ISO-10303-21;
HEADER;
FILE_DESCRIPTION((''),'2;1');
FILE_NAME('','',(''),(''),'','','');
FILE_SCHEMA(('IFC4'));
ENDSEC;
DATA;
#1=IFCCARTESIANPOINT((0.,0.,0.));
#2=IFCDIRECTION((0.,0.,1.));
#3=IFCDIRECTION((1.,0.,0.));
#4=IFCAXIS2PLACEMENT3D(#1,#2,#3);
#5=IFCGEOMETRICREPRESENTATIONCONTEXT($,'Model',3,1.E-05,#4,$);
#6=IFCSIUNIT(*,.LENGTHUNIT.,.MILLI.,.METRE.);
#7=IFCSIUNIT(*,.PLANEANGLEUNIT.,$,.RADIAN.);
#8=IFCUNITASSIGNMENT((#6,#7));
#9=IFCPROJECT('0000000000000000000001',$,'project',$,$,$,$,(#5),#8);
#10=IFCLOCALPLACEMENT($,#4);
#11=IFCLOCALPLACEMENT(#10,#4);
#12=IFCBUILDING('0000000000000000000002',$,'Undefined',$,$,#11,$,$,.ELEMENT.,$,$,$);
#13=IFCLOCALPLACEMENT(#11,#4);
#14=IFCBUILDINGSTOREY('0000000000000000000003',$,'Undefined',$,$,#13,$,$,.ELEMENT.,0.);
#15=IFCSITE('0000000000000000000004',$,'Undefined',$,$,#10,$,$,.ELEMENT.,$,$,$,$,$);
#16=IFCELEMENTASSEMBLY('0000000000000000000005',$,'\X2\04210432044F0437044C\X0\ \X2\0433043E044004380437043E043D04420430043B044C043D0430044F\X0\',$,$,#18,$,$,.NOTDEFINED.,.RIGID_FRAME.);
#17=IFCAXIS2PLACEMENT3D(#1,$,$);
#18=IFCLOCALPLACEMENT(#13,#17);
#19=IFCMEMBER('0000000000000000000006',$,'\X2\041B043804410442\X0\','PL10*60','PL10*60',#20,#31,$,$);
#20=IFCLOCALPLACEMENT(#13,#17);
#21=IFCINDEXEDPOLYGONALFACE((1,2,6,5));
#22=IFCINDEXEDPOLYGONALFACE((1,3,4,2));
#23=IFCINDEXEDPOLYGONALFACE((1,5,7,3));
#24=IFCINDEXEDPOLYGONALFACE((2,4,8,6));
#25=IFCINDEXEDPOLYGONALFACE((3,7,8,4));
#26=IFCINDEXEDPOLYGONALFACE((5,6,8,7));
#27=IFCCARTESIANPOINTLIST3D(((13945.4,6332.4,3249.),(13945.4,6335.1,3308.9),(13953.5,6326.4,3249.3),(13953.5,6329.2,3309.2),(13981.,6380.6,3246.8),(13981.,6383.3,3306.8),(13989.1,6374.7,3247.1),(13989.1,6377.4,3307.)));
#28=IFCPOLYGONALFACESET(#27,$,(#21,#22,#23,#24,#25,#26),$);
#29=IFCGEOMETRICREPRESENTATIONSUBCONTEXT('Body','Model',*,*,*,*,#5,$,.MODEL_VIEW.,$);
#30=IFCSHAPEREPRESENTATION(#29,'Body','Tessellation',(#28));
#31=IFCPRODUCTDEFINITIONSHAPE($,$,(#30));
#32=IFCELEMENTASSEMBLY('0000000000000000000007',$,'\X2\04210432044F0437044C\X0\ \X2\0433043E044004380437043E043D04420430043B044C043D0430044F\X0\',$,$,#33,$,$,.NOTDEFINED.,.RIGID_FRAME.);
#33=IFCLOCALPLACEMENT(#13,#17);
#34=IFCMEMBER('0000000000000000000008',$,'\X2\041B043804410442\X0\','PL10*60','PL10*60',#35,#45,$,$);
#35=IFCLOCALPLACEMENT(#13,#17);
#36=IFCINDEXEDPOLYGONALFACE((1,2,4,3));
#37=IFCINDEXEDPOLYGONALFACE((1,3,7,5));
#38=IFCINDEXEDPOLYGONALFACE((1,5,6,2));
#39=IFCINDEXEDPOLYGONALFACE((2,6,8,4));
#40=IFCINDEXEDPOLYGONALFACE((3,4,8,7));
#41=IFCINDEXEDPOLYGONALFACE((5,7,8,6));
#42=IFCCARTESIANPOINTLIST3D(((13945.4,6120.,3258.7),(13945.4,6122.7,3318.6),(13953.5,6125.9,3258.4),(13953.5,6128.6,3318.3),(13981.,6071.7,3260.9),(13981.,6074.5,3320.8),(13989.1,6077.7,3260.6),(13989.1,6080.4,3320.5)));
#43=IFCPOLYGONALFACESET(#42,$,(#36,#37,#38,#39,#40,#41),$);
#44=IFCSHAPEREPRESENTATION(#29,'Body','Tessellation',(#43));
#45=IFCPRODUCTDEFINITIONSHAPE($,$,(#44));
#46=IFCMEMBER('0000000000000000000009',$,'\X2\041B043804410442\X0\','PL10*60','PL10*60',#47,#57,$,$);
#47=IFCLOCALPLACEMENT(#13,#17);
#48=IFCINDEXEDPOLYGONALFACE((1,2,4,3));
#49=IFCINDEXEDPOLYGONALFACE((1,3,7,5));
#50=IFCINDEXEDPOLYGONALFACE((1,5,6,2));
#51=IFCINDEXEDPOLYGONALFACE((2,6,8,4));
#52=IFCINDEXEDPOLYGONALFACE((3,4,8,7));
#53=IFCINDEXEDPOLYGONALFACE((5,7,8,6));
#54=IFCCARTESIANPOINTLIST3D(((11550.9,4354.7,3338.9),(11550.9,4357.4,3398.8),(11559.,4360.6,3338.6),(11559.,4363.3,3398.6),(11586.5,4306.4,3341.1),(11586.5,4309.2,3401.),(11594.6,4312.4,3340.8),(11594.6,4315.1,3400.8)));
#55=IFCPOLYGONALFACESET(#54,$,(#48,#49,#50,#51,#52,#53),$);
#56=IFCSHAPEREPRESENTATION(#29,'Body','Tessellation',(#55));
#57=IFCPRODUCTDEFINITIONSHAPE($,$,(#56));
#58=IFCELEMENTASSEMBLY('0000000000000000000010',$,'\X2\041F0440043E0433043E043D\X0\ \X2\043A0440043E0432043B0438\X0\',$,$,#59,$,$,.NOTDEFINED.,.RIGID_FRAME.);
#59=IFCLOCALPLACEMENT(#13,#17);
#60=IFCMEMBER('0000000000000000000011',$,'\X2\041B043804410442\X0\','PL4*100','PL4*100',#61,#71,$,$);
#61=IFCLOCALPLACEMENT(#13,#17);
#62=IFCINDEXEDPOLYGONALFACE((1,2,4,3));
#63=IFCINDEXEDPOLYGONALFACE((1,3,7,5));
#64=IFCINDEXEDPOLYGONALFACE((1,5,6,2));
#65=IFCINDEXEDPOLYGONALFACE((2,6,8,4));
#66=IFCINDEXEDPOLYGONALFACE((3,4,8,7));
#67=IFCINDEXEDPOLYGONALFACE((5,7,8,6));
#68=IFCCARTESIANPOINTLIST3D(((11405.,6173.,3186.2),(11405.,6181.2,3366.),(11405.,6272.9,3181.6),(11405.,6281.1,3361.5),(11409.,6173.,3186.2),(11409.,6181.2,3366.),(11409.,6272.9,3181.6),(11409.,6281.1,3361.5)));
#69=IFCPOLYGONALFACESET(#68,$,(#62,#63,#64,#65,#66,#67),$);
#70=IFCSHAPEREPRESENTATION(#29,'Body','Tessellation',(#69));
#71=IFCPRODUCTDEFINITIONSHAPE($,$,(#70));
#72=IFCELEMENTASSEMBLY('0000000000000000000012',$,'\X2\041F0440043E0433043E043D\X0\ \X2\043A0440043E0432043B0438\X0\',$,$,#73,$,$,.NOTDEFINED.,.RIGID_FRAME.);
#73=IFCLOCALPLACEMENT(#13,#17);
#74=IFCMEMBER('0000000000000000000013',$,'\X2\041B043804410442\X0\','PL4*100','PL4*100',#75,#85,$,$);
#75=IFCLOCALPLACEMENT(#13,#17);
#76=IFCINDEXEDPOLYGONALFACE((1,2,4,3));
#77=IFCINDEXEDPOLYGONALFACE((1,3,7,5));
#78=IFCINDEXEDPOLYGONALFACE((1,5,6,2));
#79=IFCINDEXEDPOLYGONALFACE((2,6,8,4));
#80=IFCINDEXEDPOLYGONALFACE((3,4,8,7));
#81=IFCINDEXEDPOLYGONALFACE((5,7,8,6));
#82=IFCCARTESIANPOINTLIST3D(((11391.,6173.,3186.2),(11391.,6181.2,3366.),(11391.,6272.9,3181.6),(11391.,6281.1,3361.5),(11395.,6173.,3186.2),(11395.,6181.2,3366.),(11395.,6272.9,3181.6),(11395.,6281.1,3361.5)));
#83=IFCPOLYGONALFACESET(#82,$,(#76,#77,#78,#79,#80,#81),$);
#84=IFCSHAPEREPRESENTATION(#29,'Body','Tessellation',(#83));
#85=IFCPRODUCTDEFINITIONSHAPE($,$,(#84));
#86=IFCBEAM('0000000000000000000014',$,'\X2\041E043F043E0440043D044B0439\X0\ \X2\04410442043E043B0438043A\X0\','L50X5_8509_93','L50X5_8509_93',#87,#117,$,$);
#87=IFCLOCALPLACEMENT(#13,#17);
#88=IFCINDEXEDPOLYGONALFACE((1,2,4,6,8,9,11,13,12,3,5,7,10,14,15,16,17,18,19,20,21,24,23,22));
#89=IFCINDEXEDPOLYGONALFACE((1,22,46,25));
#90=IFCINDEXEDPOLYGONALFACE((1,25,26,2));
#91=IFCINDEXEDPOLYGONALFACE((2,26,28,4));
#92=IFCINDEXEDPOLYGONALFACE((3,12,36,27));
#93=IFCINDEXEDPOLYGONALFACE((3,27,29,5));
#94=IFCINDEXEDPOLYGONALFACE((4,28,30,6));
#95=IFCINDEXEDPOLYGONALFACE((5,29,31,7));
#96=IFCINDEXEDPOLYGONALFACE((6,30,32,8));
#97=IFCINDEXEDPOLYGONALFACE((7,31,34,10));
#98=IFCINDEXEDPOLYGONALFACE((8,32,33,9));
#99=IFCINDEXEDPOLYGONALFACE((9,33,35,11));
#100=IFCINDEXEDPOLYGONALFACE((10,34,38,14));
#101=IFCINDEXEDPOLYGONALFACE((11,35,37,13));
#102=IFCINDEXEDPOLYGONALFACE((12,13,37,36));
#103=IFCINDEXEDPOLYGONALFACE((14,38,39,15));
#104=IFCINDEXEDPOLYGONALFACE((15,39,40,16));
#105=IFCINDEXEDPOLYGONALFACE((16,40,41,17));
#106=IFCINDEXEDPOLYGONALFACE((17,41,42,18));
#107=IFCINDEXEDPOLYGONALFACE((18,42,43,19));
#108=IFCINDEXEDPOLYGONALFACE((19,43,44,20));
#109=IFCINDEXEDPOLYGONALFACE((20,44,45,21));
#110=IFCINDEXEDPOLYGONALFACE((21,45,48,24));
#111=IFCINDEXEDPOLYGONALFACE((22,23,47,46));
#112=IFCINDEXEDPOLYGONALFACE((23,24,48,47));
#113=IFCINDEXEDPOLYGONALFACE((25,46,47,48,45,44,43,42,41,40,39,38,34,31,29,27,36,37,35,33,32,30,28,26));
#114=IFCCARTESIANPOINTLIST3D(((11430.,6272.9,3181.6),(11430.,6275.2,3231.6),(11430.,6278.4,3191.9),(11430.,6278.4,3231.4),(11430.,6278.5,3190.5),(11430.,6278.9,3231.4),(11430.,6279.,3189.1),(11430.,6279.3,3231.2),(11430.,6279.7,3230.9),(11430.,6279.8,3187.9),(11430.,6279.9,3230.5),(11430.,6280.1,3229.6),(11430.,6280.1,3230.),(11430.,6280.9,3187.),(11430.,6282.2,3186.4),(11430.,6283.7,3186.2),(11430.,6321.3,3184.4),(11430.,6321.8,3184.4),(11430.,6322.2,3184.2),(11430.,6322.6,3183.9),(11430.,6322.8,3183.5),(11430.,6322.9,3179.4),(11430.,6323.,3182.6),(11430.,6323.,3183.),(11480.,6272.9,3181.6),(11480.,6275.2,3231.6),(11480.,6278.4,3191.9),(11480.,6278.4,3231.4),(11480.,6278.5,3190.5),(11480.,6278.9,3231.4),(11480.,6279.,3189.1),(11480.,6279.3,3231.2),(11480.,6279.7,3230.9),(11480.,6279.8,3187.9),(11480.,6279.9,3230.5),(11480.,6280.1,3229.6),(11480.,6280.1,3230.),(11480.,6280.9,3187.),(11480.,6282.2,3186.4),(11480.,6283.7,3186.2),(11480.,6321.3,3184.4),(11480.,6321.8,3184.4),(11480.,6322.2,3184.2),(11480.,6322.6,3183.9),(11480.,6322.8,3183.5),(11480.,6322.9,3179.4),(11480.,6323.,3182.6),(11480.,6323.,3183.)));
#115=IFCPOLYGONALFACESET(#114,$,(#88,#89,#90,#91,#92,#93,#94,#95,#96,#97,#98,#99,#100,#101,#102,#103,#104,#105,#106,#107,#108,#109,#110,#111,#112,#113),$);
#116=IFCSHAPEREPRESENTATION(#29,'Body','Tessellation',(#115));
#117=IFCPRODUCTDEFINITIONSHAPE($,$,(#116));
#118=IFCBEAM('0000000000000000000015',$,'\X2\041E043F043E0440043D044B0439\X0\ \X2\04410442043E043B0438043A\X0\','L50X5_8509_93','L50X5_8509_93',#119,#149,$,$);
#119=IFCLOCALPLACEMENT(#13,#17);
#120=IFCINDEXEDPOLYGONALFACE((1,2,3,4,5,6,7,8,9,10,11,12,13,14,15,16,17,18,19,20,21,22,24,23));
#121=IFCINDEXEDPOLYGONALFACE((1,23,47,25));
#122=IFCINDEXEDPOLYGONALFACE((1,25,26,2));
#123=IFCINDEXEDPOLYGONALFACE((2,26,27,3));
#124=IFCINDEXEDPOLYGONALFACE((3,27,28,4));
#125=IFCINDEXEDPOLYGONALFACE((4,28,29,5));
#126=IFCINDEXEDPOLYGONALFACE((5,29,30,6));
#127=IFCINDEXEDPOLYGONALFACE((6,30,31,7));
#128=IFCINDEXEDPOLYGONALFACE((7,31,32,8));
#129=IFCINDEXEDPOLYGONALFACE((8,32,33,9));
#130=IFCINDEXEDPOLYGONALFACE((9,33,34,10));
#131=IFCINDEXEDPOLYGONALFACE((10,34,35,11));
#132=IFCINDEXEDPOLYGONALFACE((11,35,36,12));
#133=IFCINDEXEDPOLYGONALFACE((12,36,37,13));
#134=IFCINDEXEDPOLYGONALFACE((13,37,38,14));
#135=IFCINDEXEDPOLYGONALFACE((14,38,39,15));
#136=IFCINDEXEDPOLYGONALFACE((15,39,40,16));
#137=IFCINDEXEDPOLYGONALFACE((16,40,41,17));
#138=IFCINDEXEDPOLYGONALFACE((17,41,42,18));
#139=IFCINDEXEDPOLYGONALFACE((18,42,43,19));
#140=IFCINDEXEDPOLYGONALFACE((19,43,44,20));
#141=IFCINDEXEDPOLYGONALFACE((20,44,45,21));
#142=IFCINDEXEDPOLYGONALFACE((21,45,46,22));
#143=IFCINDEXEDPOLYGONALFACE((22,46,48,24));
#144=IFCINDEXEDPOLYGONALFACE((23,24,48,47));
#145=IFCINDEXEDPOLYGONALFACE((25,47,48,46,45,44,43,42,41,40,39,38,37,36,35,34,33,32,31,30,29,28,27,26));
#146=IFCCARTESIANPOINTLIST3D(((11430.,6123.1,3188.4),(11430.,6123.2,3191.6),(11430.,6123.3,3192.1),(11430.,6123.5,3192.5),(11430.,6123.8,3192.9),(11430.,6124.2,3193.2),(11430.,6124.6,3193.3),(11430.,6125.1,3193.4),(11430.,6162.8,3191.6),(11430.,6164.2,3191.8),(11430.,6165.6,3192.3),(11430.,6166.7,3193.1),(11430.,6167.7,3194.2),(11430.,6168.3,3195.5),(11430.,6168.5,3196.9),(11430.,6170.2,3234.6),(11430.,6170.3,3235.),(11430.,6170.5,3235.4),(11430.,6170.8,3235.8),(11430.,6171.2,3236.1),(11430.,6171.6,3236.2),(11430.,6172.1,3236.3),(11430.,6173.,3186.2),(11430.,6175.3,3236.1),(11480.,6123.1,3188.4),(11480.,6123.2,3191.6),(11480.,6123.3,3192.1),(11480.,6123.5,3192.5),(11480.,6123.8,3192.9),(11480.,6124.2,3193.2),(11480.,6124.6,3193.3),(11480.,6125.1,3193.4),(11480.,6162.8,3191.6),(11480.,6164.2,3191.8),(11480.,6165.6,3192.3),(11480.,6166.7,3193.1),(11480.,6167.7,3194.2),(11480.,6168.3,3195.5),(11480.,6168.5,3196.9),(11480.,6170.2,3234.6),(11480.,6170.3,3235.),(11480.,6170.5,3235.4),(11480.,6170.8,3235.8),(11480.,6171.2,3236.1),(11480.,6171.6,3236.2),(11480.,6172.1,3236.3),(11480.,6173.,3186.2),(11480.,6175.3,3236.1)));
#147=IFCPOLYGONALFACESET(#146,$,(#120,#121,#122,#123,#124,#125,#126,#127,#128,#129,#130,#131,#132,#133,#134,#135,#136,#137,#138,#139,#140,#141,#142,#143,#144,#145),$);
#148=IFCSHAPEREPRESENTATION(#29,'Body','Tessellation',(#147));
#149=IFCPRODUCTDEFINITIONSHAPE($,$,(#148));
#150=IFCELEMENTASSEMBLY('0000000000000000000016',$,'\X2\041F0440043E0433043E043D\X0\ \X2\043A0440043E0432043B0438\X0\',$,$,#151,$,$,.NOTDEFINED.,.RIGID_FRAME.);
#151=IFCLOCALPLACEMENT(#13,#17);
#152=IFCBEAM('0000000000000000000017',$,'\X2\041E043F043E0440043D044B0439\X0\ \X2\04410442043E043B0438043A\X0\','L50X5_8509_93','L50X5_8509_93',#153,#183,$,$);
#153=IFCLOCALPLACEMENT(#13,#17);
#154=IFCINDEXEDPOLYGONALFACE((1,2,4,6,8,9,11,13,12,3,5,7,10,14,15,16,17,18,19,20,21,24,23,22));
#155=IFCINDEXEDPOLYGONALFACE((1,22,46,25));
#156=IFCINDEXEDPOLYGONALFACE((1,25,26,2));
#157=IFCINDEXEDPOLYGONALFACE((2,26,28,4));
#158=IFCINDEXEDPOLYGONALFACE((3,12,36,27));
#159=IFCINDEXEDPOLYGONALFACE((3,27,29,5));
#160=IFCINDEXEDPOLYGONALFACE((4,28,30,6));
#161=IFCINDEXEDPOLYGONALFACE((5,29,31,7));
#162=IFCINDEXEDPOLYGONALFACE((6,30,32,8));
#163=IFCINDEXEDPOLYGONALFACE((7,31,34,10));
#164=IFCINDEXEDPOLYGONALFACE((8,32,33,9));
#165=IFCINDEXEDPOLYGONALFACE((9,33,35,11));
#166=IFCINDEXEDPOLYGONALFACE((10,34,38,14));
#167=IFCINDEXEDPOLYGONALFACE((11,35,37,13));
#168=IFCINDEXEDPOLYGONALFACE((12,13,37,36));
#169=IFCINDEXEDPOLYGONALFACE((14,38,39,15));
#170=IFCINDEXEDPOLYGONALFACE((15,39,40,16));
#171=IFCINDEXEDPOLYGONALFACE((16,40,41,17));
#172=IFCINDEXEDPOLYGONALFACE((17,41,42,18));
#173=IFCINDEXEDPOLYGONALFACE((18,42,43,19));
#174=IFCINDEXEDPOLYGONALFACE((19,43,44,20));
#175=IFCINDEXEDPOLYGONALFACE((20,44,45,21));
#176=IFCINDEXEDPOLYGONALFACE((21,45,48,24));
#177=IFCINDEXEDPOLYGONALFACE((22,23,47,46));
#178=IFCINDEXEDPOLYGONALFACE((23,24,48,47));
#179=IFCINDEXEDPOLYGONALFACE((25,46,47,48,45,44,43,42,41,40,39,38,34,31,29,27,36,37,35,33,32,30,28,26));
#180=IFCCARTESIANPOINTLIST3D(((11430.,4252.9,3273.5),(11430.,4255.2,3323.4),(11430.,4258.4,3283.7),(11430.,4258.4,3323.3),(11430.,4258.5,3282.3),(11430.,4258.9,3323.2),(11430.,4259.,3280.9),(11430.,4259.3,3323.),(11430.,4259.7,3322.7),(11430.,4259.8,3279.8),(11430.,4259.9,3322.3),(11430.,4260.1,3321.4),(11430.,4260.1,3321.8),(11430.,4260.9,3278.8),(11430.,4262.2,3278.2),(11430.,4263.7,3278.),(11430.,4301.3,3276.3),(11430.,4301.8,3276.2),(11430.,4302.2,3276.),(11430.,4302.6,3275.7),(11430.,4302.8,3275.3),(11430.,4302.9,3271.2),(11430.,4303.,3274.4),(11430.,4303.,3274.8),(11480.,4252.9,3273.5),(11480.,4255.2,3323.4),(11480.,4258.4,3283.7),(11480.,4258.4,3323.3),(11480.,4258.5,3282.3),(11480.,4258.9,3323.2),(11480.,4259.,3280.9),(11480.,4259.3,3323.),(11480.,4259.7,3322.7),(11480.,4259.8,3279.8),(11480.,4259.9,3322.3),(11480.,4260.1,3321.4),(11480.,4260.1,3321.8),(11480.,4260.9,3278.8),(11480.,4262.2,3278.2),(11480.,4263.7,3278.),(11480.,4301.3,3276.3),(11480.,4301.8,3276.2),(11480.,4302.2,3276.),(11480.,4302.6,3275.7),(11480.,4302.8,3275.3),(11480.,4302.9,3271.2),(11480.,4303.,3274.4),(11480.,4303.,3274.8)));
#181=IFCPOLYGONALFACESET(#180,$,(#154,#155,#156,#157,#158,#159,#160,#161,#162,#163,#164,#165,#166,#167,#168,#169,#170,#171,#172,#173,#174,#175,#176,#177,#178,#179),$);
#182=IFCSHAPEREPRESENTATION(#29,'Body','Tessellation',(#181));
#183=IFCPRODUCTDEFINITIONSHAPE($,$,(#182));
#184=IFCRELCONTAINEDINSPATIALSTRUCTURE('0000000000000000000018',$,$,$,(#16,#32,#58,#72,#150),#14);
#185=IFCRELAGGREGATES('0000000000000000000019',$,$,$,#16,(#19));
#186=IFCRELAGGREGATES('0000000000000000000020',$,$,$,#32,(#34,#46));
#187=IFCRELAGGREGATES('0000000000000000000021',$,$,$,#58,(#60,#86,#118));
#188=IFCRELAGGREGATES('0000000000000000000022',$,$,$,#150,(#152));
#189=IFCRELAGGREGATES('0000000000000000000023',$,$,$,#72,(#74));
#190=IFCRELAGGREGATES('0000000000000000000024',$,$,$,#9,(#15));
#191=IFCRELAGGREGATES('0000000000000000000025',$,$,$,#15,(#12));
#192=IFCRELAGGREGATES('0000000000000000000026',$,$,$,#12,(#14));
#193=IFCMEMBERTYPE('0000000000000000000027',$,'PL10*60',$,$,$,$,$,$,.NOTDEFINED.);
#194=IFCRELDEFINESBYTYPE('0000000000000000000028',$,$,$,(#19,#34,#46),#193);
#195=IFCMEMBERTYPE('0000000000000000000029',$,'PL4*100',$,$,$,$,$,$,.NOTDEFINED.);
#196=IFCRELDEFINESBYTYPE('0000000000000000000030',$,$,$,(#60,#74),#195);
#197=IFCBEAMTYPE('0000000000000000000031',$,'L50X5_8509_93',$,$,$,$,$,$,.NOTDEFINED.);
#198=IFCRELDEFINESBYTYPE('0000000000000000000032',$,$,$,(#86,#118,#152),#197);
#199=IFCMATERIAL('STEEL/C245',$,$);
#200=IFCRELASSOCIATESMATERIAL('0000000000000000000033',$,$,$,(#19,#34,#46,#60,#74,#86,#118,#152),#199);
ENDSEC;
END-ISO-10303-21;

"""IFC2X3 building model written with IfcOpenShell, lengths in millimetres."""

from ifc_helpers import new_model, si_unit, frame, origin_with_axes, origin_2d_with_axis, place, context, subcontext, project, spatial, rectangle, l_section, extrude, material, type_object, element, aggregate, save


model = new_model("IFC2X3")

# Units and contexts
model_context = context("Model", 3, precision=1e-05, world=origin_with_axes())
body_context = subcontext(model_context, "Body", "Model", "MODEL_VIEW")
ifc_project = project(units=[si_unit("LENGTHUNIT", "METRE", prefix="MILLI"), si_unit("PLANEANGLEUNIT", "RADIAN")], contexts=[model_context])

# Site, building, storey
site_placement = place(None, origin_with_axes())
site = spatial("IfcSite", under=ifc_project, at=site_placement, Name="Undefined", CompositionType="ELEMENT")
building_placement = place(site_placement, origin_with_axes())
building = spatial("IfcBuilding", under=site, at=building_placement, Name="Undefined", CompositionType="ELEMENT")
storey_placement = place(building_placement, origin_with_axes())
storey = spatial("IfcBuildingStorey", under=building, at=storey_placement, Name="Undefined", CompositionType="ELEMENT", Elevation=0.0)

# Element assembly, member
assembly_1_placement = place(storey_placement, origin_with_axes())
assembly_1 = element("IfcElementAssembly", 1, at=assembly_1_placement, inside=storey, Name="Связь горизонтальная", AssemblyPlace="NOTDEFINED", PredefinedType="RIGID_FRAME")
ifc_material_1 = material(Name="STEEL/C245")
member_type_1 = type_object("IfcMemberType", Name="PL10*60", PredefinedType="NOTDEFINED")
member_1_placement = place(assembly_1_placement, frame((13967.3, 6353.5, 3248.0), z_axis=(-0.593795, -0.803786, 0.036536), x_axis=(0.0, 0.045408, 0.998969)))
member_1 = element("IfcMember", 2, at=member_1_placement, type_object=member_type_1, material=ifc_material_1, Name="Лист", Description="PL10*60", ObjectType="PL10*60", context=body_context, shape_type="SweptSolid", body=[
    extrude(rectangle(XDim=10.0, YDim=60.0, at=origin_2d_with_axis()), frame((60.0, 0.0, 0.0), z_axis=(-1.0, 0.0, 0.0), x_axis=(0.0, -1.0, 0.0)), (0.0, 0.0, 1.0), 60.0),
])

# Element assembly, members
assembly_2_placement = place(storey_placement, origin_with_axes())
assembly_2 = element("IfcElementAssembly", 3, at=assembly_2_placement, inside=storey, Name="Связь горизонтальная", AssemblyPlace="NOTDEFINED", PredefinedType="RIGID_FRAME")
member_2_placement = place(assembly_2_placement, frame((13967.3, 6098.8, 3259.6), z_axis=(0.593795, -0.803786, 0.036536), x_axis=(0.0, 0.045408, 0.998969)))
member_2 = element("IfcMember", 4, at=member_2_placement, type_object=member_type_1, material=ifc_material_1, Name="Лист", Description="PL10*60", ObjectType="PL10*60", context=body_context, shape_type="SweptSolid", body=[
    extrude(rectangle(XDim=10.0, YDim=60.0, at=origin_2d_with_axis()), frame((60.0, 0.0, 0.0), z_axis=(-1.0, 0.0, 0.0), x_axis=(0.0, -1.0, 0.0)), (0.0, 0.0, 1.0), 60.0),
])
member_3_placement = place(assembly_2_placement, frame((11572.7, 4333.5, 3339.9), z_axis=(-0.593795, 0.803786, -0.036536), x_axis=(0.0, 0.045408, 0.998969)))
member_3 = element("IfcMember", 5, at=member_3_placement, type_object=member_type_1, material=ifc_material_1, Name="Лист", Description="PL10*60", ObjectType="PL10*60", context=body_context, shape_type="SweptSolid", body=[
    extrude(rectangle(XDim=10.0, YDim=60.0, at=origin_2d_with_axis()), frame((60.0, 0.0, 0.0), z_axis=(-1.0, 0.0, 0.0), x_axis=(0.0, -1.0, 0.0)), (0.0, 0.0, 1.0), 60.0),
])

# Element assemblies, members
assembly_3_placement = place(storey_placement, origin_with_axes())
assembly_3 = element("IfcElementAssembly", 6, at=assembly_3_placement, inside=storey, Name="Прогон кровли", AssemblyPlace="NOTDEFINED", PredefinedType="RIGID_FRAME")
member_type_2 = type_object("IfcMemberType", Name="PL4*100", PredefinedType="NOTDEFINED")
member_4_placement = place(assembly_3_placement, frame((11407.0, 6223.0, 3183.9), z_axis=(0.0, -0.998969, 0.045408), x_axis=(0.0, 0.045408, 0.998969)))
member_4 = element("IfcMember", 7, at=member_4_placement, type_object=member_type_2, material=ifc_material_1, Name="Лист", Description="PL4*100", ObjectType="PL4*100", context=body_context, shape_type="SweptSolid", body=[
    extrude(rectangle(XDim=4.0, YDim=100.0, at=origin_2d_with_axis()), frame((180.0, 0.0, 0.0), z_axis=(-1.0, 0.0, 0.0), x_axis=(0.0, -1.0, 0.0)), (0.0, 0.0, 1.0), 180.0),
])
assembly_4_placement = place(storey_placement, origin_with_axes())
assembly_4 = element("IfcElementAssembly", 8, at=assembly_4_placement, inside=storey, Name="Прогон кровли", AssemblyPlace="NOTDEFINED", PredefinedType="RIGID_FRAME")
member_5_placement = place(assembly_4_placement, frame((11393.0, 6223.0, 3183.9), z_axis=(0.0, 0.998969, -0.045408), x_axis=(0.0, 0.045408, 0.998969)))
member_5 = element("IfcMember", 9, at=member_5_placement, type_object=member_type_2, material=ifc_material_1, Name="Лист", Description="PL4*100", ObjectType="PL4*100", context=body_context, shape_type="SweptSolid", body=[
    extrude(rectangle(XDim=4.0, YDim=100.0, at=origin_2d_with_axis()), frame((180.0, 0.0, 0.0), z_axis=(-1.0, 0.0, 0.0), x_axis=(0.0, -1.0, 0.0)), (0.0, 0.0, 1.0), 180.0),
])

# Beams
beam_type = type_object("IfcBeamType", Name="L50X5_8509_93", PredefinedType="NOTDEFINED")
beam_1_placement = place(assembly_3_placement, frame((11430.0, 6299.0, 3205.5), z_axis=(0.0, 0.998969, -0.045408), x_axis=(1.0, 0.0, 0.0)))
beam_1 = element("IfcBeam", 10, at=beam_1_placement, type_object=beam_type, material=ifc_material_1, Name="Опорный столик", Description="L50X5_8509_93", ObjectType="L50X5_8509_93", context=body_context, shape_type="SweptSolid", body=[
    extrude(l_section(Depth=50.0, Width=50.0, Thickness=5.0, FilletRadius=5.5, EdgeRadius=1.8, at=origin_2d_with_axis()), frame((50.0, 0.0, 0.0), z_axis=(-1.0, 0.0, 0.0), x_axis=(0.0, -1.0, 0.0)), (0.0, 0.0, 1.0), 50.0),
])
beam_2_placement = place(assembly_3_placement, frame((11480.0, 6149.2, 3212.3), z_axis=(0.0, -0.998969, 0.045408), x_axis=(-1.0, 0.0, 0.0)))
beam_2 = element("IfcBeam", 11, at=beam_2_placement, type_object=beam_type, material=ifc_material_1, Name="Опорный столик", Description="L50X5_8509_93", ObjectType="L50X5_8509_93", context=body_context, shape_type="SweptSolid", body=[
    extrude(l_section(Depth=50.0, Width=50.0, Thickness=5.0, FilletRadius=5.5, EdgeRadius=1.8, at=origin_2d_with_axis()), frame((50.0, 0.0, 0.0), z_axis=(-1.0, 0.0, 0.0), x_axis=(0.0, -1.0, 0.0)), (0.0, 0.0, 1.0), 50.0),
])

# Element assembly, beam
assembly_5_placement = place(storey_placement, origin_with_axes())
assembly_5 = element("IfcElementAssembly", 12, at=assembly_5_placement, inside=storey, Name="Прогон кровли", AssemblyPlace="NOTDEFINED", PredefinedType="RIGID_FRAME")
beam_3_placement = place(assembly_5_placement, frame((11430.0, 4279.1, 3297.3), z_axis=(0.0, 0.998969, -0.045408), x_axis=(1.0, 0.0, 0.0)))
beam_3 = element("IfcBeam", 13, at=beam_3_placement, type_object=beam_type, material=ifc_material_1, Name="Опорный столик", Description="L50X5_8509_93", ObjectType="L50X5_8509_93", context=body_context, shape_type="SweptSolid", body=[
    extrude(l_section(Depth=50.0, Width=50.0, Thickness=5.0, FilletRadius=5.5, EdgeRadius=1.8, at=origin_2d_with_axis()), frame((50.0, 0.0, 0.0), z_axis=(-1.0, 0.0, 0.0), x_axis=(0.0, -1.0, 0.0)), (0.0, 0.0, 1.0), 50.0),
])

aggregate(assembly_1, [member_1])
aggregate(assembly_2, [member_2, member_3])
aggregate(assembly_3, [member_4, beam_1, beam_2])
aggregate(assembly_5, [beam_3])
aggregate(assembly_4, [member_5])

save(model, "model.ifc")
